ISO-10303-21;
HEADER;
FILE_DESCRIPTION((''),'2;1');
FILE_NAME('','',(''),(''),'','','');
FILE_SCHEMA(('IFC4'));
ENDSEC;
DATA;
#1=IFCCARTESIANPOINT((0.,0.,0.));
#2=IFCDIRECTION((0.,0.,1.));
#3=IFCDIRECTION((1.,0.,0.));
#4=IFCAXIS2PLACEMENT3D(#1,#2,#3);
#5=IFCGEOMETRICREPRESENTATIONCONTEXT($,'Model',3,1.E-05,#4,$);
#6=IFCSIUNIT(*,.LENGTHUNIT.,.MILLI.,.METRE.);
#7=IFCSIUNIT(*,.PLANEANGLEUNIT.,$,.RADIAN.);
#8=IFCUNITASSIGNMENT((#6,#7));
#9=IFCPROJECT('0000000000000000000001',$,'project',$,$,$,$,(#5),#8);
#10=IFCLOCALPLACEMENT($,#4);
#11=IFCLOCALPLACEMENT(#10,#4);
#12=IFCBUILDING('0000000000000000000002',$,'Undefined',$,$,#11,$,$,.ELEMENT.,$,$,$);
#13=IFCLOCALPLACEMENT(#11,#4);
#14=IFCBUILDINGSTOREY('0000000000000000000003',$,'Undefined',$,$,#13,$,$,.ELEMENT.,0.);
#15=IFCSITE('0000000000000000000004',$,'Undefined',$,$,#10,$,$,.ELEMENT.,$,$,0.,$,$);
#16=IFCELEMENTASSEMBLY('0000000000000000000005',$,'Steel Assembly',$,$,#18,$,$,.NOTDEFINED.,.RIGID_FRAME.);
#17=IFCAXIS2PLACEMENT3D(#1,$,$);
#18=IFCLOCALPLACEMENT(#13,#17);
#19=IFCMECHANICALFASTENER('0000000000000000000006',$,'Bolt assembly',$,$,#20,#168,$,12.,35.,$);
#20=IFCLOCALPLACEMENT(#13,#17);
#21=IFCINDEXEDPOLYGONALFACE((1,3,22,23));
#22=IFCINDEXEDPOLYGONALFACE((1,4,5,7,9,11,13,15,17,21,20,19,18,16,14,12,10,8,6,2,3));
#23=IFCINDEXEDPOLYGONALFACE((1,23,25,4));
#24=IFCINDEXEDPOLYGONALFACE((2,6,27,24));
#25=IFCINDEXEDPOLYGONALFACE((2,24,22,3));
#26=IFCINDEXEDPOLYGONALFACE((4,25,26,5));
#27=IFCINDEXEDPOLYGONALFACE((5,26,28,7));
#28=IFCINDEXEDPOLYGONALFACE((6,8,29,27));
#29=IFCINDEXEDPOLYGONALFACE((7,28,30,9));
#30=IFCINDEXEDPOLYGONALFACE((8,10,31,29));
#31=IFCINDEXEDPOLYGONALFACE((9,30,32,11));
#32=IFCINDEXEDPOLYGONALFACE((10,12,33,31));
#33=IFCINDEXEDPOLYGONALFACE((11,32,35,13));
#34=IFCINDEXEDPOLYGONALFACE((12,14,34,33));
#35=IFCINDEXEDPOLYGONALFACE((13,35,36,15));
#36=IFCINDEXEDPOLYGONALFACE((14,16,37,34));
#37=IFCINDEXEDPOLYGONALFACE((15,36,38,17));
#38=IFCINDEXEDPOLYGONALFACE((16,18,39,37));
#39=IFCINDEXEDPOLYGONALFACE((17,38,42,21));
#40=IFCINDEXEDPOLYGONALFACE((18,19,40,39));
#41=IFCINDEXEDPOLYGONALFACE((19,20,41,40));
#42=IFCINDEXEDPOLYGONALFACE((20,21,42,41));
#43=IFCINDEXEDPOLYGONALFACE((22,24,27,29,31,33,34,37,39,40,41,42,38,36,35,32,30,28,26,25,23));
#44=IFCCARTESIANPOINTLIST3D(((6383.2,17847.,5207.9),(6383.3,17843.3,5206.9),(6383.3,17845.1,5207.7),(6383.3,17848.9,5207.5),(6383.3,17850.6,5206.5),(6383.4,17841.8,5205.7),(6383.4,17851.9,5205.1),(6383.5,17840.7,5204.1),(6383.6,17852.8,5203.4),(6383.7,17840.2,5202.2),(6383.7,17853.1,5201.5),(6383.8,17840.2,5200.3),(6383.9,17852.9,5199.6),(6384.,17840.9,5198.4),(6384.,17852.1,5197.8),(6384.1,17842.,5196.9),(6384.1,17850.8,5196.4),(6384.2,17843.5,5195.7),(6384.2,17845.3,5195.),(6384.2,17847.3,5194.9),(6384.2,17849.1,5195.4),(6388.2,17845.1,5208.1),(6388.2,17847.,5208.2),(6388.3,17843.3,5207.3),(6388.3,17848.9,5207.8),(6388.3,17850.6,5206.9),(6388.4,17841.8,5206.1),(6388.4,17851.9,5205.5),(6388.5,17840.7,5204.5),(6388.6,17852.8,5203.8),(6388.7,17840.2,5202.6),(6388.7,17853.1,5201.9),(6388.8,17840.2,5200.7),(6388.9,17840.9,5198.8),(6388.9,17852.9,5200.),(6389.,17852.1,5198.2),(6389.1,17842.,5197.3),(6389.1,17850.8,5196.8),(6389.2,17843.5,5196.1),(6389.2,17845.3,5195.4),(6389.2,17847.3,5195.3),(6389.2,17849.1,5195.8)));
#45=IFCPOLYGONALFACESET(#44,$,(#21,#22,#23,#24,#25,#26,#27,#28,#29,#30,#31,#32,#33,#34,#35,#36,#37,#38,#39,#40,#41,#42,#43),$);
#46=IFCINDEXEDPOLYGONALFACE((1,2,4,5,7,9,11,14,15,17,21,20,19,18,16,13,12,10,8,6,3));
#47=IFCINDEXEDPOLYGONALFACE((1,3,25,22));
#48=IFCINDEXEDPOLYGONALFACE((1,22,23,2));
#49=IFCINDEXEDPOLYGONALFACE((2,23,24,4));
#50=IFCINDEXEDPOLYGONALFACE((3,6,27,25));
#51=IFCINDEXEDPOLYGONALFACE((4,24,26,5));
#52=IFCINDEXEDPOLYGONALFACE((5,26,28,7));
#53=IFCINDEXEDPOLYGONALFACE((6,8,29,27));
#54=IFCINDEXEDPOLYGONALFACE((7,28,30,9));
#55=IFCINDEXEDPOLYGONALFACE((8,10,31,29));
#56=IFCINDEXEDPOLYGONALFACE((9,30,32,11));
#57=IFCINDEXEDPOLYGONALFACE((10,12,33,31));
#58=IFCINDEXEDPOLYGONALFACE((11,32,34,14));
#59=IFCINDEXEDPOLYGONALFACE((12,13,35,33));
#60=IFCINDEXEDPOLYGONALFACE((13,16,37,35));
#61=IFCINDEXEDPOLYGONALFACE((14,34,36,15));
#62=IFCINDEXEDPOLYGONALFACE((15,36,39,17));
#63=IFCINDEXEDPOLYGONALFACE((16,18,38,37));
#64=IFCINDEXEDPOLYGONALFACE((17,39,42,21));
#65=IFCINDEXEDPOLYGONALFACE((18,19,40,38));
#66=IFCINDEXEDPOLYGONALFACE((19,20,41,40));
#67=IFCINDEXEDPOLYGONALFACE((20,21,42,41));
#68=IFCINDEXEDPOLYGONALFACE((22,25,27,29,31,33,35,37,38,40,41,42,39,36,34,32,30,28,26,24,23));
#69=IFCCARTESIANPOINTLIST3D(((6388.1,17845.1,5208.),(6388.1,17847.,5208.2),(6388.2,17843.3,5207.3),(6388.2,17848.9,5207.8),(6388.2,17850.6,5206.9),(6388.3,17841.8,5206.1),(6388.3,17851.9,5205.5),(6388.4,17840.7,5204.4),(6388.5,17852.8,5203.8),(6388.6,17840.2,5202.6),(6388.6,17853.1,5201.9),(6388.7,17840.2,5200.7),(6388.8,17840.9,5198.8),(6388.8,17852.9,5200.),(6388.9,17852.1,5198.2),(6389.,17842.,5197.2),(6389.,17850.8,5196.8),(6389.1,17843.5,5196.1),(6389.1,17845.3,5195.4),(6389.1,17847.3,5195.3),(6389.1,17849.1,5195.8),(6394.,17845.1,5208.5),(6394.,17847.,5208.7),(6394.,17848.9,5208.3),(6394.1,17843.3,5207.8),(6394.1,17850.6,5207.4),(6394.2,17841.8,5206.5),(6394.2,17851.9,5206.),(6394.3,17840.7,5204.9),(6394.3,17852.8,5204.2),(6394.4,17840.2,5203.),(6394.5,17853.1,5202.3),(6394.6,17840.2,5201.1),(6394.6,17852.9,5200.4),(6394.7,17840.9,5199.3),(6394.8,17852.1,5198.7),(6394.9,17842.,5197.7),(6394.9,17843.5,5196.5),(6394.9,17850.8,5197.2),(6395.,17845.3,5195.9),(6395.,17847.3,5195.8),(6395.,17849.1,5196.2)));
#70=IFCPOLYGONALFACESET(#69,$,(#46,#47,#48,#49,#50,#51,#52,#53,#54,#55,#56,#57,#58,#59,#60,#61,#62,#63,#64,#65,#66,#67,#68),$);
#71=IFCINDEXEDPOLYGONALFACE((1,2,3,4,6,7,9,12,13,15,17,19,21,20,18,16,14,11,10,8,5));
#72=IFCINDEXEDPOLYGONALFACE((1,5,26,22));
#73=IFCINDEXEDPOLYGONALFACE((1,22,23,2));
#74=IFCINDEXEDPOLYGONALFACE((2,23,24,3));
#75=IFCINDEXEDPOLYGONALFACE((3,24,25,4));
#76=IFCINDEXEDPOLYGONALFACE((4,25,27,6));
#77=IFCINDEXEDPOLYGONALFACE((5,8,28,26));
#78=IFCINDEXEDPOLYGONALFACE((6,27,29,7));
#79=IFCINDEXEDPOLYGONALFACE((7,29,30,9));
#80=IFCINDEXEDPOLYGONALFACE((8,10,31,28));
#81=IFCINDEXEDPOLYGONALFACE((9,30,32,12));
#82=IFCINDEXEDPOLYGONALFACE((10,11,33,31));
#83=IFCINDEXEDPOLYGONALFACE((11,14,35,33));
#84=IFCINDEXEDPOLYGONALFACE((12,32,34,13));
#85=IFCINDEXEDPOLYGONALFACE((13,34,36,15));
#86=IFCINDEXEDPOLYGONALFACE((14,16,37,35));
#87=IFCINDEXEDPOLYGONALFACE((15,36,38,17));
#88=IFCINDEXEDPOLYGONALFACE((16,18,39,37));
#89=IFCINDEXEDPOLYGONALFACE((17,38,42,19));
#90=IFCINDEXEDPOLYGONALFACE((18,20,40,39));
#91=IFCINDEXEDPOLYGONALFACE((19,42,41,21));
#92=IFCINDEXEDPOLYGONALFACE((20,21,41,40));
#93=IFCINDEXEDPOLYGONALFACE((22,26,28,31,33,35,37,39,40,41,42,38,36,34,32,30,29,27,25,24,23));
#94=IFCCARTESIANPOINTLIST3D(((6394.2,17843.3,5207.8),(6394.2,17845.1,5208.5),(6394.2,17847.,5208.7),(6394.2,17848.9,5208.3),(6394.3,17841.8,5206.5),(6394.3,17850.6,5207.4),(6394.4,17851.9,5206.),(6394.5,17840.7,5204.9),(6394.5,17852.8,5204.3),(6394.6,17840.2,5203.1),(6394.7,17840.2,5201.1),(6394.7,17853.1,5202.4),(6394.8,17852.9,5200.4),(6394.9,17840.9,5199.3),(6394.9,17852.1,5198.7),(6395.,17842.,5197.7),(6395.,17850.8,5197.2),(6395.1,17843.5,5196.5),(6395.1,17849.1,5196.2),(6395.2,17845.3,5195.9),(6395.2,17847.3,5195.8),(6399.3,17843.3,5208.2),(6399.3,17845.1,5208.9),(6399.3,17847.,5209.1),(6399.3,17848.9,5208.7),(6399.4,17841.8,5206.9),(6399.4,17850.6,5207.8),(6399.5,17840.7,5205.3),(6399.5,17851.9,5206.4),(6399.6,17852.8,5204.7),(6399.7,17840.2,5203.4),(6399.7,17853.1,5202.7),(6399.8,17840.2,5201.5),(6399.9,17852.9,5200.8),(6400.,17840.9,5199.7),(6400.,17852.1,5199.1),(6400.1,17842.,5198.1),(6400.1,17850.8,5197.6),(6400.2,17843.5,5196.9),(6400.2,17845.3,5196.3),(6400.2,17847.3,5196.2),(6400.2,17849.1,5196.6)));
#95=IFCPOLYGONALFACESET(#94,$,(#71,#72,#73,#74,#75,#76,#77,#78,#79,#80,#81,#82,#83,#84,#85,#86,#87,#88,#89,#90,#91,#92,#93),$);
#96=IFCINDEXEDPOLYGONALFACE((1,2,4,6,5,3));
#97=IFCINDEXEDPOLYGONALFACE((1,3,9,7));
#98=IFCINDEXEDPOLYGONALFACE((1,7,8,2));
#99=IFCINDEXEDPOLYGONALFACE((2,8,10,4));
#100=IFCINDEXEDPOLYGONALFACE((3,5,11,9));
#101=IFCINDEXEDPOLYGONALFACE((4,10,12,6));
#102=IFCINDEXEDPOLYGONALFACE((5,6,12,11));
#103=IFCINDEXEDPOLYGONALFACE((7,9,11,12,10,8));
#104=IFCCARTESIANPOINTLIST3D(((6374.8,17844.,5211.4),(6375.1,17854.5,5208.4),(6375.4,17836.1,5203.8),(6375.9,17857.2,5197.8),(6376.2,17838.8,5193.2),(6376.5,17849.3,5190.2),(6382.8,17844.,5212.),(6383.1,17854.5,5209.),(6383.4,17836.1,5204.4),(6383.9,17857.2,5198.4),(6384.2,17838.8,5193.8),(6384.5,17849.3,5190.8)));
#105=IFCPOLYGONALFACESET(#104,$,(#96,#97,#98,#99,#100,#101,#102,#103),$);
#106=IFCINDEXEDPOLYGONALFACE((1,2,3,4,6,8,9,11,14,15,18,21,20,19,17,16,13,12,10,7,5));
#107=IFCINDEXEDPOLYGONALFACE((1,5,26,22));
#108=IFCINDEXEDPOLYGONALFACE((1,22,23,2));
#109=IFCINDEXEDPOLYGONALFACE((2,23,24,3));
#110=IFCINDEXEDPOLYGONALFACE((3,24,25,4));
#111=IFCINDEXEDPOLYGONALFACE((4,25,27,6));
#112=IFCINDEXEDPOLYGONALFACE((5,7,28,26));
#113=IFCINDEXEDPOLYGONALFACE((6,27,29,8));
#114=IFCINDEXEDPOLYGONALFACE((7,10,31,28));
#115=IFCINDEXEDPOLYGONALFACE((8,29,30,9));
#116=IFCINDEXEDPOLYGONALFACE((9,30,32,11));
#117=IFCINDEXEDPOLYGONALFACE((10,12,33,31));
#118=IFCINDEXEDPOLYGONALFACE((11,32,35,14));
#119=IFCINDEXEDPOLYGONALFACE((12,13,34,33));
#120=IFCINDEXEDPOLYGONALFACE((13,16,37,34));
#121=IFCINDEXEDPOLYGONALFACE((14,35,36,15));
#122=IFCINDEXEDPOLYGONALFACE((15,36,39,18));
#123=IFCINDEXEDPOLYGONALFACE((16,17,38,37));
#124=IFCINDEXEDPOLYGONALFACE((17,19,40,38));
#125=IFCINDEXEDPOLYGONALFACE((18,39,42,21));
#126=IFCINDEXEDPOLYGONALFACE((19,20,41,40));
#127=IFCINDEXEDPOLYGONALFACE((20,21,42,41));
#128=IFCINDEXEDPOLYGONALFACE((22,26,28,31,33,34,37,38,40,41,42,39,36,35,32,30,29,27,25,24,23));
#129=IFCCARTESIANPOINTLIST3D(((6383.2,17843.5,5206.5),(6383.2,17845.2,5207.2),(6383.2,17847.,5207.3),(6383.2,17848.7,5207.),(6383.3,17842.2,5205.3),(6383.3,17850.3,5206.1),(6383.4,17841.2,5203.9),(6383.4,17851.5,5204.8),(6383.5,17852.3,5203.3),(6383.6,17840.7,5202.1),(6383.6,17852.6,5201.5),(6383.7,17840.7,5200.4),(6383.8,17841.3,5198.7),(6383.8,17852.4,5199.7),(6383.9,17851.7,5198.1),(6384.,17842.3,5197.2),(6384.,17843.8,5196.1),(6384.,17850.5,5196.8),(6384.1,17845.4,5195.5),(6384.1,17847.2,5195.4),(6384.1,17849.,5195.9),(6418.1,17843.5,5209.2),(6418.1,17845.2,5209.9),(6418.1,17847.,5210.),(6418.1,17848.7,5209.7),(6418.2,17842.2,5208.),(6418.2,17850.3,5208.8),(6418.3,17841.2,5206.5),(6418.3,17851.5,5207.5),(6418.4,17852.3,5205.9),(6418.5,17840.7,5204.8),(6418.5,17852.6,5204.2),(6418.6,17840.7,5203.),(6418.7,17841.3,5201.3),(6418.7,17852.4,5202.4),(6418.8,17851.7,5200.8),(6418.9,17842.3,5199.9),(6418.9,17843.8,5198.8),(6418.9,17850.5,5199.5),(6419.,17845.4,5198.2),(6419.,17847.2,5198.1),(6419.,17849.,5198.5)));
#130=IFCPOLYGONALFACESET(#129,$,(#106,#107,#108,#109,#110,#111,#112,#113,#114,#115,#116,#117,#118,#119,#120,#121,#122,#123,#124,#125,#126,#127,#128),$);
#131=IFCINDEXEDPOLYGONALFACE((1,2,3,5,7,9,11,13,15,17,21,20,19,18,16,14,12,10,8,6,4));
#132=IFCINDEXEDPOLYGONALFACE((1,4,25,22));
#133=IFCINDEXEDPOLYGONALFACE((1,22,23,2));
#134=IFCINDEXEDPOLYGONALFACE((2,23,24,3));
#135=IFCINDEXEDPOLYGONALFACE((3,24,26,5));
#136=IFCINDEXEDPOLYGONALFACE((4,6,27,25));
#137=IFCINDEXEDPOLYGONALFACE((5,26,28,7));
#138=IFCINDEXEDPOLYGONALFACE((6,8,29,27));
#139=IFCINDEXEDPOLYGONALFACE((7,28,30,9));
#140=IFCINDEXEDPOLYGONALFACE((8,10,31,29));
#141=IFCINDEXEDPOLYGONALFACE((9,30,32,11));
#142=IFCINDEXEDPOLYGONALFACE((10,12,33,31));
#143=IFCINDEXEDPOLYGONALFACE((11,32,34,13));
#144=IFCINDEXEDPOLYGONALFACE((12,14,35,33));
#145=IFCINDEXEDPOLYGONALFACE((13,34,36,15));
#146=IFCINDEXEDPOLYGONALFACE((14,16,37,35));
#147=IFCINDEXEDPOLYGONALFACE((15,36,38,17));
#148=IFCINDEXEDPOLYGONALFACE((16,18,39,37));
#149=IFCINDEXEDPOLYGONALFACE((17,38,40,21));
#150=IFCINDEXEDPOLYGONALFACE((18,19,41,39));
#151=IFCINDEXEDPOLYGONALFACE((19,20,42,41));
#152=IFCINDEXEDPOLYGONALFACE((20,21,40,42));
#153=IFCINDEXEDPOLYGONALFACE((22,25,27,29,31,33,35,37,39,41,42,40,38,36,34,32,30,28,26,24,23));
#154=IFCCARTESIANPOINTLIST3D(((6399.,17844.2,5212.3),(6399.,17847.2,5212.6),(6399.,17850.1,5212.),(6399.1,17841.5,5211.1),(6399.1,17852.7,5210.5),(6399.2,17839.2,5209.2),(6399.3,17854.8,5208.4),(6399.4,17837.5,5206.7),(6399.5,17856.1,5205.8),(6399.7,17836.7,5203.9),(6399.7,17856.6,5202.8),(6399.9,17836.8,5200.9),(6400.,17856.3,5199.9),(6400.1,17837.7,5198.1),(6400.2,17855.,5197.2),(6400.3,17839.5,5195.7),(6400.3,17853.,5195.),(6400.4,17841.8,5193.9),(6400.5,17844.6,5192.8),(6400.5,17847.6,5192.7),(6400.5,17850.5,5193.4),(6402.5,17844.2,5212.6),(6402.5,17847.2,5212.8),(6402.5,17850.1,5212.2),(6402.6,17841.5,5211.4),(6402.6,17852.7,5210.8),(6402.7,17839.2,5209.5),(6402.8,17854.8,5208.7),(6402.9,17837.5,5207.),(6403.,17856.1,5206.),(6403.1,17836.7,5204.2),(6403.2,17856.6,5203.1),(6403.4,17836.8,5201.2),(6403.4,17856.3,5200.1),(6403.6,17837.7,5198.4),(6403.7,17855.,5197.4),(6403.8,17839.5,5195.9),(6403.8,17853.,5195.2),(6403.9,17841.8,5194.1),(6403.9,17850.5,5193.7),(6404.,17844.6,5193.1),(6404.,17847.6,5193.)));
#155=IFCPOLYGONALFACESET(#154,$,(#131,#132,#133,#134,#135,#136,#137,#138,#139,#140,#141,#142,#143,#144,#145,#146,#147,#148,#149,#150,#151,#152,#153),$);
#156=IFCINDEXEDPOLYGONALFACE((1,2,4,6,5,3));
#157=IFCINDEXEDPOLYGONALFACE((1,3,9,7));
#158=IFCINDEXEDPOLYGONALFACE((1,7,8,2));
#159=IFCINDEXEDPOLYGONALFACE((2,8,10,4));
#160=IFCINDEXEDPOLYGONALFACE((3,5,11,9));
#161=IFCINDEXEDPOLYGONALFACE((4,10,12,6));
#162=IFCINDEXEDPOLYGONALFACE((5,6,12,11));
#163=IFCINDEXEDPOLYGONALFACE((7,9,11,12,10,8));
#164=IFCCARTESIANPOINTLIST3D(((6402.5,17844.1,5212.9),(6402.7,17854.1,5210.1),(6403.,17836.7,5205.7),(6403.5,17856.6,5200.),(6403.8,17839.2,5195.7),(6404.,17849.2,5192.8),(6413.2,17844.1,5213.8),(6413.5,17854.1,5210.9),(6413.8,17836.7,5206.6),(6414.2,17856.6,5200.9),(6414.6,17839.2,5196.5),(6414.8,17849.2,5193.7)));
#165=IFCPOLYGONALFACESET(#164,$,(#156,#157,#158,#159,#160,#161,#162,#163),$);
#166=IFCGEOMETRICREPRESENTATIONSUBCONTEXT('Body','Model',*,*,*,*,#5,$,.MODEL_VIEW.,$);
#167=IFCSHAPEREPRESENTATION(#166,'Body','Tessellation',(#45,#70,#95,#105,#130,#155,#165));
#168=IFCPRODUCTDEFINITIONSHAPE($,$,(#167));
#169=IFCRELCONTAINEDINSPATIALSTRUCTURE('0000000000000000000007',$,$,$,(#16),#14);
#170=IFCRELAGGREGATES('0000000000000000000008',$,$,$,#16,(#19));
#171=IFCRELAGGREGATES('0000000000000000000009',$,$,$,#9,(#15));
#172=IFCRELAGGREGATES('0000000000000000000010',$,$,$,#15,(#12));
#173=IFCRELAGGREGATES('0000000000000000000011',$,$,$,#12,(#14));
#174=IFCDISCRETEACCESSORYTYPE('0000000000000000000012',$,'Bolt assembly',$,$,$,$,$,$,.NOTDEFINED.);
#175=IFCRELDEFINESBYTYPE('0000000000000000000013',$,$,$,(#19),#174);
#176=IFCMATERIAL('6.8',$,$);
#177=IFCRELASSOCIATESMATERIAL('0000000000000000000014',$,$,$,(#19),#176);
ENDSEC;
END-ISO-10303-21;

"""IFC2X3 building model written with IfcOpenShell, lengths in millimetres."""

from ifc_helpers import new_model, si_unit, frame, origin_with_axes, origin_2d_with_axis, place, context, subcontext, project, spatial, polyline, circle, outline, extrude, source, transform, mapped, material, type_object, element, aggregate, save


model = new_model("IFC2X3")

# Units and contexts
model_context = context("Model", 3, precision=1e-05, world=origin_with_axes())
body_context = subcontext(model_context, "Body", "Model", "MODEL_VIEW")
ifc_project = project(units=[si_unit("LENGTHUNIT", "METRE", prefix="MILLI"), si_unit("PLANEANGLEUNIT", "RADIAN")], contexts=[model_context])

# Site, building, storey
site_placement = place(None, origin_with_axes())
site = spatial("IfcSite", under=ifc_project, at=site_placement, Name="Undefined", CompositionType="ELEMENT", RefElevation=0.0)
building_placement = place(site_placement, origin_with_axes())
building = spatial("IfcBuilding", under=site, at=building_placement, Name="Undefined", CompositionType="ELEMENT")
storey_placement = place(building_placement, origin_with_axes())
storey = spatial("IfcBuildingStorey", under=building, at=storey_placement, Name="Undefined", CompositionType="ELEMENT", Elevation=0.0)

# Element assembly
assembly_1_placement = place(storey_placement, origin_with_axes())
assembly_1 = element("IfcElementAssembly", 1, at=assembly_1_placement, inside=storey, Name="Steel Assembly", AssemblyPlace="NOTDEFINED", PredefinedType="RIGID_FRAME")

# Shared definitions
ifc_material_1 = material(Name="6.8")
discrete_accessory_type_1 = type_object("IfcDiscreteAccessoryType", Name="Bolt assembly")

# Mechanical fastener
shared_shape_1 = source(origin_with_axes(), body_context, "Body", "SweptSolid", [
    extrude(circle(Radius=6.5, at=origin_2d_with_axis()), frame((0.0, 0.1, 0.0), z_axis=(0.0, 1.0, 0.0), x_axis=(1.0, 0.0, 0.0)), (0.0, 0.0, 1.0), 5.0),
    extrude(circle(Radius=6.5, at=origin_2d_with_axis()), frame((0.0, 5.0, 0.0), z_axis=(0.0, 1.0, 0.0), x_axis=(1.0, 0.0, 0.0)), (0.0, 0.0, 1.0), 5.9),
    extrude(circle(Radius=6.5, at=origin_2d_with_axis()), frame((0.0, 11.1, 0.0), z_axis=(0.0, 1.0, 0.0), x_axis=(1.0, 0.0, 0.0)), (0.0, 0.0, 1.0), 5.1),
    extrude(outline(polyline([(11.0, 0.0), (5.5, 9.5), (-5.5, 9.5), (-11.0, 0.0), (-5.5, -9.5), (5.5, -9.5), (11.0, 0.0)])), frame((0.0, -8.0, 0.0), z_axis=(0.0, 1.0, 0.0), x_axis=(1.0, 0.0, 0.0)), (0.0, 0.0, 1.0), 8.0),
    extrude(circle(Radius=6.0, at=origin_2d_with_axis()), frame((0.0, 0.0, 0.0), z_axis=(0.0, 1.0, 0.0), x_axis=(1.0, 0.0, 0.0)), (0.0, 0.0, 1.0), 35.0),
    extrude(circle(Radius=10.0, at=origin_2d_with_axis()), frame((0.0, 16.2, 0.0), z_axis=(0.0, 1.0, 0.0), x_axis=(1.0, 0.0, 0.0)), (0.0, 0.0, 1.0), 3.5),
    extrude(outline(polyline([(10.4, 0.0), (5.2, 9.0), (-5.2, 9.0), (-10.4, 0.0), (-5.2, -9.0), (5.2, -9.0), (10.4, 0.0)])), frame((0.0, 19.7, 0.0), z_axis=(0.0, 1.0, 0.0), x_axis=(1.0, 0.0, 0.0)), (0.0, 0.0, 1.0), 10.8),
])
mechanical_fastener_1_placement = place(assembly_1_placement, frame((6383.6, 17846.6, 5201.4), z_axis=(-0.055107, -0.695516, 0.716394), x_axis=(0.053344, -0.71851, -0.693468)))
mechanical_fastener_1 = element("IfcMechanicalFastener", 2, at=mechanical_fastener_1_placement, type_object=discrete_accessory_type_1, material=ifc_material_1, Name="Bolt assembly", NominalDiameter=12.0, NominalLength=35.0, context=body_context, shape_type="MappedRepresentation", body=[
    mapped(shared_shape_1, transform((0.0, 0.0, 0.0))),
])
aggregate(assembly_1, [mechanical_fastener_1])

save(model, "model.ifc")
